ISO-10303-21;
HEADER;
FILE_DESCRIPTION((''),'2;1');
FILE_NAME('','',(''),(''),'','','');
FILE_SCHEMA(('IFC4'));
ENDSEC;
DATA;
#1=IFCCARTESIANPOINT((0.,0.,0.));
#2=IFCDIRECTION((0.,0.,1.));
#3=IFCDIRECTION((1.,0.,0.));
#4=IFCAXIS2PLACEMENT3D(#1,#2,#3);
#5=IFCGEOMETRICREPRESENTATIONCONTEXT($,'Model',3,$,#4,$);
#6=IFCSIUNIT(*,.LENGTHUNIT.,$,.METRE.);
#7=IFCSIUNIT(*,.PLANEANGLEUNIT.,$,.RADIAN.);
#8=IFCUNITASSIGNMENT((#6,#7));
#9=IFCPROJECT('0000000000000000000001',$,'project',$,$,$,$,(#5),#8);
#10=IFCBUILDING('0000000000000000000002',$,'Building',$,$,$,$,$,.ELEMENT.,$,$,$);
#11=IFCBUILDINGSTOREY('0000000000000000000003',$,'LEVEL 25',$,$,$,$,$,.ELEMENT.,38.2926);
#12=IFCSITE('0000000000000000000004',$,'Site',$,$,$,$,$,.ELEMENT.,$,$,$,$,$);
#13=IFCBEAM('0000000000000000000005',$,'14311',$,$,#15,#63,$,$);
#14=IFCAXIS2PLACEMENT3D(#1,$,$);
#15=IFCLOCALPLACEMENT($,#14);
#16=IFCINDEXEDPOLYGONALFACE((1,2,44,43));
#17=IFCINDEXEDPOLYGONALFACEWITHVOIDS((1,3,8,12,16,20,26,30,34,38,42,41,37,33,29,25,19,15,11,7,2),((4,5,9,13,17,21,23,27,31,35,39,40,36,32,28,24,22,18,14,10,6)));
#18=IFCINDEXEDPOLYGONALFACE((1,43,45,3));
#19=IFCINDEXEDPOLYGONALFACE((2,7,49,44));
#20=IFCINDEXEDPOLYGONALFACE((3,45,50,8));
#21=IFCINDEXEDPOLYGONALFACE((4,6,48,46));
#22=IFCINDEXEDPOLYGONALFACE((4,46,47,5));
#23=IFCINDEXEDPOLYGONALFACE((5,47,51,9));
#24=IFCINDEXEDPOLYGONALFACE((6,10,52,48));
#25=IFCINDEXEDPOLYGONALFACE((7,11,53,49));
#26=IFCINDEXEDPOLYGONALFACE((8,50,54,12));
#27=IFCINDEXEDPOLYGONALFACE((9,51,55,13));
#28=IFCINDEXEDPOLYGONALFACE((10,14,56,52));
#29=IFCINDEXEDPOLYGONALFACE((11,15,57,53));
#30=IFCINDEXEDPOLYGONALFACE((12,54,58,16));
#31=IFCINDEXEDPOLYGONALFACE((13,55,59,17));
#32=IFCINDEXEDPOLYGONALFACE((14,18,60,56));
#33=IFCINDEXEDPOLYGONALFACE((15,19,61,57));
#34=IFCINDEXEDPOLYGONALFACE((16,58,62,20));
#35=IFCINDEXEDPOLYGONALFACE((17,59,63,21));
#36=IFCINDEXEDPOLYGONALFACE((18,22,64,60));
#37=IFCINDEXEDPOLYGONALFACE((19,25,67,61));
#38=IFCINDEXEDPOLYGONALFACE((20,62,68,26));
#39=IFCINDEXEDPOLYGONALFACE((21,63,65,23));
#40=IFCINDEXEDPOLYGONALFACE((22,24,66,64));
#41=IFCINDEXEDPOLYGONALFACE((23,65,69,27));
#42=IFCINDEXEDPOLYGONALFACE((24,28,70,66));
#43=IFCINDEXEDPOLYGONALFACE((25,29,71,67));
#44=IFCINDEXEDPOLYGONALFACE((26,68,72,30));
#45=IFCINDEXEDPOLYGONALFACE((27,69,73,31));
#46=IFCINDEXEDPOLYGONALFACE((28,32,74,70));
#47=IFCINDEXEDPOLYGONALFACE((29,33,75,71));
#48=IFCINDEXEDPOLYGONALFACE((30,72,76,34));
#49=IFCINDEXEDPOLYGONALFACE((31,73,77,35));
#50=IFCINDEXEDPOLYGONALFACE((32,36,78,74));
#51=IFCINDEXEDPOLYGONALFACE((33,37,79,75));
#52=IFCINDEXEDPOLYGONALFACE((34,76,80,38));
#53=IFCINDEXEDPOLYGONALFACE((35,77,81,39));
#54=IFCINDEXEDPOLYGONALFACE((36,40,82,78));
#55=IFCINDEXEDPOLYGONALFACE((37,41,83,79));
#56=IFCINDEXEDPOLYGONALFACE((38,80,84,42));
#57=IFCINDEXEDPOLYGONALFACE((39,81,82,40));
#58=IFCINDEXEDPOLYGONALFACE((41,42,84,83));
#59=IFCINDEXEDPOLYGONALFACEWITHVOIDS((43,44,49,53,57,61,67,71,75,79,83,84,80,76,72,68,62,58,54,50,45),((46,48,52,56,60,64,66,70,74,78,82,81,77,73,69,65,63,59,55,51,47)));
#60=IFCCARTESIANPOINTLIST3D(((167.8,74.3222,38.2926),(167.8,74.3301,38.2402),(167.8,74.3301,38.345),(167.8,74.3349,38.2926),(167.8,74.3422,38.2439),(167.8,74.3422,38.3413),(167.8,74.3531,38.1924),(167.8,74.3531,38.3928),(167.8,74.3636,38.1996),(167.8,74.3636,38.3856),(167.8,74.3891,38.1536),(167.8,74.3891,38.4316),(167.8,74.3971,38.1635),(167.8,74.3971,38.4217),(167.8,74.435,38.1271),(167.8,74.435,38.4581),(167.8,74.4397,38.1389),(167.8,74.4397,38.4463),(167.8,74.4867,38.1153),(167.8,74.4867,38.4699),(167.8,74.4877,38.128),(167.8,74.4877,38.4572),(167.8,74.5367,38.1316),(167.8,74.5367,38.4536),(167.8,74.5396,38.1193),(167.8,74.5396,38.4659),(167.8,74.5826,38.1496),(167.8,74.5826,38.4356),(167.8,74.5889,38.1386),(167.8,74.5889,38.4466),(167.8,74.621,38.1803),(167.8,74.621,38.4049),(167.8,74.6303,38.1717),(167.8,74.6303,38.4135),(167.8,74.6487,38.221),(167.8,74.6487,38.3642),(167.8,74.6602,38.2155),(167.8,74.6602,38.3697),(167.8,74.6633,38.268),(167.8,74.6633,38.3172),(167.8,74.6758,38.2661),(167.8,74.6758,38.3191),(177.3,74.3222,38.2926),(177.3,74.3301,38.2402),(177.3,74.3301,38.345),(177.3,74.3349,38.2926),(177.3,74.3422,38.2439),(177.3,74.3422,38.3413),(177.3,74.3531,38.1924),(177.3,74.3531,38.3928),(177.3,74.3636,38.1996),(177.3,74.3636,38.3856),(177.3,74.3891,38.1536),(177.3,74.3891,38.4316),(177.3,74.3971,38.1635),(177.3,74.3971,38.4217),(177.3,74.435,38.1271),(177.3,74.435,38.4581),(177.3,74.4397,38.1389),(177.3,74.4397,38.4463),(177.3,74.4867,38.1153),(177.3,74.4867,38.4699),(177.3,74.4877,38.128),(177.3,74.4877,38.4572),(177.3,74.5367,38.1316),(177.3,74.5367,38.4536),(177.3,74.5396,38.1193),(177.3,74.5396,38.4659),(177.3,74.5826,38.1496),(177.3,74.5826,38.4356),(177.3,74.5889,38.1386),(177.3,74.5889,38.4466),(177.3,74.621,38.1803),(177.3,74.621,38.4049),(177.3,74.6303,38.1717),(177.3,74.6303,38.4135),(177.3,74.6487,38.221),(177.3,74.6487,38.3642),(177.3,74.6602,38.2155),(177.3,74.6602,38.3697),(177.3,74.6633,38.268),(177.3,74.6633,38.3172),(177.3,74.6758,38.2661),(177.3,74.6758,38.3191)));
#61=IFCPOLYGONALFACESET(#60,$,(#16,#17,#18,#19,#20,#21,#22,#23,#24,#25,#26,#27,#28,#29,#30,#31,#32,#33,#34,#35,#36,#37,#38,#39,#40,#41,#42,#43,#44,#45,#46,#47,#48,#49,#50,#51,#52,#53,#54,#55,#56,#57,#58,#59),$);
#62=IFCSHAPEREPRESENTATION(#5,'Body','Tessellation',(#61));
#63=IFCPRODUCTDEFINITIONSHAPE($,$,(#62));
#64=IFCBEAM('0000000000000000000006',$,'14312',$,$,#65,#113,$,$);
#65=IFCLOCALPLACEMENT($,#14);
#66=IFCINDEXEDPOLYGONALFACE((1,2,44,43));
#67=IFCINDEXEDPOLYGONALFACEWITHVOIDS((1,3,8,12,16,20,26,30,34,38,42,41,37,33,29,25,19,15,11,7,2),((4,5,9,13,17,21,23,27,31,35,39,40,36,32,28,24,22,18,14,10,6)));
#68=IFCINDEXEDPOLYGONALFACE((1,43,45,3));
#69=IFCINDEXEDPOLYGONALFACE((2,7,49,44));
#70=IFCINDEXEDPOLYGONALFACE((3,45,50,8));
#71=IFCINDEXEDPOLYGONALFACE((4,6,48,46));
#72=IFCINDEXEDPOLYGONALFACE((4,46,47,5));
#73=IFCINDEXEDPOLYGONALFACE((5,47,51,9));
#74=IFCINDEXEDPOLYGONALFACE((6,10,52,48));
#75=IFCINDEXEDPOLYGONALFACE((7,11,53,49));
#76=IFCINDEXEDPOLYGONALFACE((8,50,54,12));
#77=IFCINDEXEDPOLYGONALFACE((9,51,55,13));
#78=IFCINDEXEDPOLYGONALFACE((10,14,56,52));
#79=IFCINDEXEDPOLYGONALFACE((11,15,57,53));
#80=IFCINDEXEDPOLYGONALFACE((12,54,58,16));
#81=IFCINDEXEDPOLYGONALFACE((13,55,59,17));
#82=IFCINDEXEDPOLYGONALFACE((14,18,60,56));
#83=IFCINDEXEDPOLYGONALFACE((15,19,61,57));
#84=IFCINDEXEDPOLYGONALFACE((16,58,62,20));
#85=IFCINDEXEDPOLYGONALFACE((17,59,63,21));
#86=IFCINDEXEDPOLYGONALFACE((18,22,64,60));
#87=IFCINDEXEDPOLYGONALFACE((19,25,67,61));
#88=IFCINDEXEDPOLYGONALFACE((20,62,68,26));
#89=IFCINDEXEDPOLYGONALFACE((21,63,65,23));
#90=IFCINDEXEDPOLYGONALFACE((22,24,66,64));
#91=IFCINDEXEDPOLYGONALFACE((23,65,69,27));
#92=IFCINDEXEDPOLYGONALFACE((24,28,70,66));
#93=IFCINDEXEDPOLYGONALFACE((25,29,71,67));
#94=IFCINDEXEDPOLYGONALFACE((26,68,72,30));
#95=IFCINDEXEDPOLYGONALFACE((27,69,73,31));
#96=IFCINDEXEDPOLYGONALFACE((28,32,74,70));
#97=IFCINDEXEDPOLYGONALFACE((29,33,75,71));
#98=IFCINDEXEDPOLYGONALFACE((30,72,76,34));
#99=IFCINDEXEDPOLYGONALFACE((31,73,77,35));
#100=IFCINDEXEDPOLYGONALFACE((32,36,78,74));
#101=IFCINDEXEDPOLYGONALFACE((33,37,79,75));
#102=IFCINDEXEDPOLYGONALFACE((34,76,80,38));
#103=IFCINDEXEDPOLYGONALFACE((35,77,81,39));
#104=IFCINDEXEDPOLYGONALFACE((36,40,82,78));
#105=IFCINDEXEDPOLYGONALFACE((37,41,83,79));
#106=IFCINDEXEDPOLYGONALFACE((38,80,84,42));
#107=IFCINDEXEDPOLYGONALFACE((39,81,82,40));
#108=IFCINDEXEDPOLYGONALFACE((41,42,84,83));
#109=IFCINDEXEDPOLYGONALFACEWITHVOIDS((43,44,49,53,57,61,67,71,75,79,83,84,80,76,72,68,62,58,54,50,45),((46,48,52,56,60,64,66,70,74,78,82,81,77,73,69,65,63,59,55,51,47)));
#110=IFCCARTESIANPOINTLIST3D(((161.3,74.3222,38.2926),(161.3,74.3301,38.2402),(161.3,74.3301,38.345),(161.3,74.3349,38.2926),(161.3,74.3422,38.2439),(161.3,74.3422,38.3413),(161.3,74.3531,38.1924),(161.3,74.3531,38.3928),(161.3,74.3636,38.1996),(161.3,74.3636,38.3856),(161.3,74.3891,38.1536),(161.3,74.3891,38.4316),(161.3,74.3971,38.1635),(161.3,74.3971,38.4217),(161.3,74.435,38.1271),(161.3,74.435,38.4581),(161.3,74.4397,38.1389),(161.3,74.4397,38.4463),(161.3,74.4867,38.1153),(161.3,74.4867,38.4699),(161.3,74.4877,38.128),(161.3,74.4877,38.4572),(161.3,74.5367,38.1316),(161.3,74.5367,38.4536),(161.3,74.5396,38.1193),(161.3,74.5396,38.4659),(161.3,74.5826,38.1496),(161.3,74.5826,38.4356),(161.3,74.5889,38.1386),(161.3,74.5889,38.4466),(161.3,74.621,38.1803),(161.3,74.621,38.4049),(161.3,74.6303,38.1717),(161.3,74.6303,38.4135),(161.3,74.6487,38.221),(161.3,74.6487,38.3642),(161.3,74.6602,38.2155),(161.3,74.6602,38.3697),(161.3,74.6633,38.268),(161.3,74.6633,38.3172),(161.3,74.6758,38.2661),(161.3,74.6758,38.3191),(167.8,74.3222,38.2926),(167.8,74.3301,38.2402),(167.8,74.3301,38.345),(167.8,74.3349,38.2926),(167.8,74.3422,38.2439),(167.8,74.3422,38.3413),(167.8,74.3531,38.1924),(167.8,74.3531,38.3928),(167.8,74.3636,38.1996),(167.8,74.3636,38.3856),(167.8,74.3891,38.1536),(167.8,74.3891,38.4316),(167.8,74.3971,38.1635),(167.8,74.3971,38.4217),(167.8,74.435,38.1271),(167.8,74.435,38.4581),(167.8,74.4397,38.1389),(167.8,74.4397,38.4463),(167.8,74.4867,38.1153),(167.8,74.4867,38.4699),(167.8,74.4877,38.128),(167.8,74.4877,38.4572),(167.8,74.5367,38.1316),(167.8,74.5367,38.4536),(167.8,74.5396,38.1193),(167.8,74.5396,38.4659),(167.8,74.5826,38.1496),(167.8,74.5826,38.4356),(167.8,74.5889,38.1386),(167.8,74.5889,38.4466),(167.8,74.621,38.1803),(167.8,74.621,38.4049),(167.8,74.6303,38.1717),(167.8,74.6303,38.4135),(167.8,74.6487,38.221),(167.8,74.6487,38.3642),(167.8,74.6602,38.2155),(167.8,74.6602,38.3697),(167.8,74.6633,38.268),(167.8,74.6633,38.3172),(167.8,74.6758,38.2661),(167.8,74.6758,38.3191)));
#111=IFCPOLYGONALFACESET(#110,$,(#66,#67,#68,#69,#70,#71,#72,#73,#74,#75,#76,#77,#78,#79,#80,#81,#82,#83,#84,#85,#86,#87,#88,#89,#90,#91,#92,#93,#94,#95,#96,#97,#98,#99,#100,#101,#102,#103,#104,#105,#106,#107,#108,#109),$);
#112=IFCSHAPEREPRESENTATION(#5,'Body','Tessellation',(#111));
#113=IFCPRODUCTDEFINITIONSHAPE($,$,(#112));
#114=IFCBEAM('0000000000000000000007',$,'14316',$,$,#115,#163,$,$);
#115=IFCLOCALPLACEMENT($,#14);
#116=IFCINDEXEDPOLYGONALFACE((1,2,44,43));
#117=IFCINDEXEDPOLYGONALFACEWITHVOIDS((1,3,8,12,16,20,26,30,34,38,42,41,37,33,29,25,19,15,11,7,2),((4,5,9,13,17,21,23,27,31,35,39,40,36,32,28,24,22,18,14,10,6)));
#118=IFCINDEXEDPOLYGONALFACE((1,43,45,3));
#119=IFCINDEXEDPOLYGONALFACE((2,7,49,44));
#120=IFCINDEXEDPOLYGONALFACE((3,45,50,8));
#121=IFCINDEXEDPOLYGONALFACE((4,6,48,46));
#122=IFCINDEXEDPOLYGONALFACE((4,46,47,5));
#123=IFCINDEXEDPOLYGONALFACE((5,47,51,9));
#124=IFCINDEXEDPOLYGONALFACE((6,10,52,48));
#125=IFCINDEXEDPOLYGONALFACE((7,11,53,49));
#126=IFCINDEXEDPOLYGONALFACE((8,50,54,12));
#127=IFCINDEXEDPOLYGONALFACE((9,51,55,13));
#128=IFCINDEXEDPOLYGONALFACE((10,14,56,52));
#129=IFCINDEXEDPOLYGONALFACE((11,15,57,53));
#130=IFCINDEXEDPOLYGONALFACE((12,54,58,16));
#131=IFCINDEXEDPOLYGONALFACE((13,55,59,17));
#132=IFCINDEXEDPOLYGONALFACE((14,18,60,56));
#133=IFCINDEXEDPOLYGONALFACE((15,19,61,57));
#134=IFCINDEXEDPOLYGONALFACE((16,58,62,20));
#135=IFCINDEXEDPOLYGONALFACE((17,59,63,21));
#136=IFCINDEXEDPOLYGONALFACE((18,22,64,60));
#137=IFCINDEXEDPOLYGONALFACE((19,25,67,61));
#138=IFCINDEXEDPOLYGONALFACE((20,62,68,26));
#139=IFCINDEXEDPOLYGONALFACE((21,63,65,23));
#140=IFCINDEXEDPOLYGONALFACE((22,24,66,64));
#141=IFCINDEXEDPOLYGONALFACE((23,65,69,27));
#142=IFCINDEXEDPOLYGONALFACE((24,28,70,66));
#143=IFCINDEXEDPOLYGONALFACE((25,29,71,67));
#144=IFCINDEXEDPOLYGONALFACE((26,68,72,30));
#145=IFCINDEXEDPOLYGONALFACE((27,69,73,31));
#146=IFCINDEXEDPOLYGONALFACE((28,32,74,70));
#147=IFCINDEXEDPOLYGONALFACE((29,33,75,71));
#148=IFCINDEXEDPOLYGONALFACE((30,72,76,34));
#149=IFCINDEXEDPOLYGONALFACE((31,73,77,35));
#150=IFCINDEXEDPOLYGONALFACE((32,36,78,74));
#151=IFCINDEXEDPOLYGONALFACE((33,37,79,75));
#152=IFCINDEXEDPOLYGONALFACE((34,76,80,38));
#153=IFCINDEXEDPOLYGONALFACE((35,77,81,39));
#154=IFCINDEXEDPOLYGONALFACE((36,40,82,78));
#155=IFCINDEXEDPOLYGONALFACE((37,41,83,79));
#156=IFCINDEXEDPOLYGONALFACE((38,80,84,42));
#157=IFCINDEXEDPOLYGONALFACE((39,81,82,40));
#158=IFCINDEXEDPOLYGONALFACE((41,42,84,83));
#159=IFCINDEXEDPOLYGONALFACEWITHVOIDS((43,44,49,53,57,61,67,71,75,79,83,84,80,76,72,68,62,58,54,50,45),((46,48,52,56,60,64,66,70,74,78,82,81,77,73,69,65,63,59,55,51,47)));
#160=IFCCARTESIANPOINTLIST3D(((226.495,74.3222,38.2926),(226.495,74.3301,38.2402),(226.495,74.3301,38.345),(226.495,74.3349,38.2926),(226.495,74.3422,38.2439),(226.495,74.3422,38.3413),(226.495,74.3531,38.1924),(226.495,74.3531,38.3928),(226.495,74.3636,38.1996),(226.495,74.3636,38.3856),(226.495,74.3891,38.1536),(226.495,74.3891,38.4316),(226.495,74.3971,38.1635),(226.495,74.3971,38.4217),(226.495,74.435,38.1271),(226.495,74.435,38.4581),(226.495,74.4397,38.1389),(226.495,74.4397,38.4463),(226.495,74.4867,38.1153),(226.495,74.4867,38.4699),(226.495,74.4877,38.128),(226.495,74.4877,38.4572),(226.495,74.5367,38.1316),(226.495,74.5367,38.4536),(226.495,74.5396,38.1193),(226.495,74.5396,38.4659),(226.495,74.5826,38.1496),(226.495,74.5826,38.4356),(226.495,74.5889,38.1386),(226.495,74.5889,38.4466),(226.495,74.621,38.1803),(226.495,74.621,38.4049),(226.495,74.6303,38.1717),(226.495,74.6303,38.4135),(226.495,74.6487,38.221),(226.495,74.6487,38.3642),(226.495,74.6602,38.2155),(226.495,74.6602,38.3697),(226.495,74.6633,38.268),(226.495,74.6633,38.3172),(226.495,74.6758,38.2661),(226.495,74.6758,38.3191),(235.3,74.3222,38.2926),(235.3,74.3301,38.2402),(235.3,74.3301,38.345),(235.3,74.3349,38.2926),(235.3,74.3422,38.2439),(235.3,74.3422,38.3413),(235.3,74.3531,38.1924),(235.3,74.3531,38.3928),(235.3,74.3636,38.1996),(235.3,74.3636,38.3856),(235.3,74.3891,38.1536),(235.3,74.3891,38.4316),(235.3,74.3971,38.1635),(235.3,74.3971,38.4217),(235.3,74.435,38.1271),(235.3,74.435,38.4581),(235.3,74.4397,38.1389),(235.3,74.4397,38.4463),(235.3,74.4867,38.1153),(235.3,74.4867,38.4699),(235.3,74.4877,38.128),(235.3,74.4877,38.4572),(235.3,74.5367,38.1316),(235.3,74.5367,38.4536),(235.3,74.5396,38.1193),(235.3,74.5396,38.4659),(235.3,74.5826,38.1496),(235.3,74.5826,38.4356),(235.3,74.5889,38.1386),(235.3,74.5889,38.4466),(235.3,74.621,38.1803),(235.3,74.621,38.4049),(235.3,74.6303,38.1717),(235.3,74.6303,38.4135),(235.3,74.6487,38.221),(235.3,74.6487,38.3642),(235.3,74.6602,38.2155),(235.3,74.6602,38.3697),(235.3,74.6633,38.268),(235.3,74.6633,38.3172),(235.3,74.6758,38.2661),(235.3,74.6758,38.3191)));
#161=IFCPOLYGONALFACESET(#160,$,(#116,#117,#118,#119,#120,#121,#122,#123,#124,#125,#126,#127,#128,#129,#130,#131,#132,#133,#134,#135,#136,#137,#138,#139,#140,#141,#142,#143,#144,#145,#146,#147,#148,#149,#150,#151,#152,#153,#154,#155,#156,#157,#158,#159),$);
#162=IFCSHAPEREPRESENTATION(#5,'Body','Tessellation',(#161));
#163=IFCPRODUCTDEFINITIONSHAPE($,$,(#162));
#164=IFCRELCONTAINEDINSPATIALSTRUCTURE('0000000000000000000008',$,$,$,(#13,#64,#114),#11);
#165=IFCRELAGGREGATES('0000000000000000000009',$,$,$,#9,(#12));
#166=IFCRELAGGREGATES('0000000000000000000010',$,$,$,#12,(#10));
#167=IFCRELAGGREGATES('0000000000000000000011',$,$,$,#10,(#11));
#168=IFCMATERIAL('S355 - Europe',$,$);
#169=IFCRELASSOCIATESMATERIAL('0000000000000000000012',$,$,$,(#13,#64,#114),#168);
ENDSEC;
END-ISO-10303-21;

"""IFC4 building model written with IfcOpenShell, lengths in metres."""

from ifc_helpers import new_model, si_unit, frame, origin_with_axes, origin_2d_with_axis, place, context, project, spatial, hollow_circle, extrude, material, material_profile, profile_set, profile_usage, element, save


model = new_model("IFC4")

# Units and contexts
model_context = context("Model", 3, world=origin_with_axes())
ifc_project = project(units=[si_unit("LENGTHUNIT", "METRE"), si_unit("PLANEANGLEUNIT", "RADIAN")], contexts=[model_context])

# Site, building, storey
site = spatial("IfcSite", under=ifc_project, Name="Site", CompositionType="ELEMENT")
building = spatial("IfcBuilding", under=site, Name="Building", CompositionType="ELEMENT")
storey = spatial("IfcBuildingStorey", under=building, Name="LEVEL 25", CompositionType="ELEMENT", Elevation=38.2926)

# Beams
ifc_material = material(Name="S355 - Europe")
ifc_material_profile_1 = material_profile(ifc_material, hollow_circle(Radius=0.1778, WallThickness=0.0127, at=origin_2d_with_axis()))
ifc_profile_set_1 = profile_set([ifc_material_profile_1])
ifc_profile_usage_1 = profile_usage(ifc_profile_set_1, cardinal=10)
beam_1_placement = place(None, frame((177.3, 74.5, 38.2926), z_axis=(-1.0, 0.0, 0.0), x_axis=(0.0, -1.0, 0.0)))
element("IfcBeam", 1, at=beam_1_placement, inside=storey, material=ifc_profile_usage_1, Name="14311", context=model_context, shape_type="SweptSolid", body=[
    extrude(hollow_circle(Radius=0.1778, WallThickness=0.0127, at=origin_2d_with_axis()), origin_with_axes(), (0.0, 0.0, 1.0), 9.5),
])
ifc_material_profile_2 = material_profile(ifc_material, hollow_circle(Radius=0.1778, WallThickness=0.0127, at=origin_2d_with_axis()))
ifc_profile_set_2 = profile_set([ifc_material_profile_2])
ifc_profile_usage_2 = profile_usage(ifc_profile_set_2, cardinal=10)
beam_2_placement = place(None, frame((167.8, 74.5, 38.2926), z_axis=(-1.0, 0.0, 0.0), x_axis=(0.0, -1.0, 0.0)))
element("IfcBeam", 2, at=beam_2_placement, inside=storey, material=ifc_profile_usage_2, Name="14312", context=model_context, shape_type="SweptSolid", body=[
    extrude(hollow_circle(Radius=0.1778, WallThickness=0.0127, at=origin_2d_with_axis()), origin_with_axes(), (0.0, 0.0, 1.0), 6.5),
])
ifc_material_profile_3 = material_profile(ifc_material, hollow_circle(Radius=0.1778, WallThickness=0.0127, at=origin_2d_with_axis()))
ifc_profile_set_3 = profile_set([ifc_material_profile_3])
ifc_profile_usage_3 = profile_usage(ifc_profile_set_3, cardinal=10)
beam_3_placement = place(None, frame((235.3, 74.5, 38.2926), z_axis=(-1.0, 0.0, 0.0), x_axis=(0.0, -1.0, 0.0)))
element("IfcBeam", 3, at=beam_3_placement, inside=storey, material=ifc_profile_usage_3, Name="14316", context=model_context, shape_type="SweptSolid", body=[
    extrude(hollow_circle(Radius=0.1778, WallThickness=0.0127, at=origin_2d_with_axis()), origin_with_axes(), (0.0, 0.0, 1.0), 8.805),
])

save(model, "model.ifc")
